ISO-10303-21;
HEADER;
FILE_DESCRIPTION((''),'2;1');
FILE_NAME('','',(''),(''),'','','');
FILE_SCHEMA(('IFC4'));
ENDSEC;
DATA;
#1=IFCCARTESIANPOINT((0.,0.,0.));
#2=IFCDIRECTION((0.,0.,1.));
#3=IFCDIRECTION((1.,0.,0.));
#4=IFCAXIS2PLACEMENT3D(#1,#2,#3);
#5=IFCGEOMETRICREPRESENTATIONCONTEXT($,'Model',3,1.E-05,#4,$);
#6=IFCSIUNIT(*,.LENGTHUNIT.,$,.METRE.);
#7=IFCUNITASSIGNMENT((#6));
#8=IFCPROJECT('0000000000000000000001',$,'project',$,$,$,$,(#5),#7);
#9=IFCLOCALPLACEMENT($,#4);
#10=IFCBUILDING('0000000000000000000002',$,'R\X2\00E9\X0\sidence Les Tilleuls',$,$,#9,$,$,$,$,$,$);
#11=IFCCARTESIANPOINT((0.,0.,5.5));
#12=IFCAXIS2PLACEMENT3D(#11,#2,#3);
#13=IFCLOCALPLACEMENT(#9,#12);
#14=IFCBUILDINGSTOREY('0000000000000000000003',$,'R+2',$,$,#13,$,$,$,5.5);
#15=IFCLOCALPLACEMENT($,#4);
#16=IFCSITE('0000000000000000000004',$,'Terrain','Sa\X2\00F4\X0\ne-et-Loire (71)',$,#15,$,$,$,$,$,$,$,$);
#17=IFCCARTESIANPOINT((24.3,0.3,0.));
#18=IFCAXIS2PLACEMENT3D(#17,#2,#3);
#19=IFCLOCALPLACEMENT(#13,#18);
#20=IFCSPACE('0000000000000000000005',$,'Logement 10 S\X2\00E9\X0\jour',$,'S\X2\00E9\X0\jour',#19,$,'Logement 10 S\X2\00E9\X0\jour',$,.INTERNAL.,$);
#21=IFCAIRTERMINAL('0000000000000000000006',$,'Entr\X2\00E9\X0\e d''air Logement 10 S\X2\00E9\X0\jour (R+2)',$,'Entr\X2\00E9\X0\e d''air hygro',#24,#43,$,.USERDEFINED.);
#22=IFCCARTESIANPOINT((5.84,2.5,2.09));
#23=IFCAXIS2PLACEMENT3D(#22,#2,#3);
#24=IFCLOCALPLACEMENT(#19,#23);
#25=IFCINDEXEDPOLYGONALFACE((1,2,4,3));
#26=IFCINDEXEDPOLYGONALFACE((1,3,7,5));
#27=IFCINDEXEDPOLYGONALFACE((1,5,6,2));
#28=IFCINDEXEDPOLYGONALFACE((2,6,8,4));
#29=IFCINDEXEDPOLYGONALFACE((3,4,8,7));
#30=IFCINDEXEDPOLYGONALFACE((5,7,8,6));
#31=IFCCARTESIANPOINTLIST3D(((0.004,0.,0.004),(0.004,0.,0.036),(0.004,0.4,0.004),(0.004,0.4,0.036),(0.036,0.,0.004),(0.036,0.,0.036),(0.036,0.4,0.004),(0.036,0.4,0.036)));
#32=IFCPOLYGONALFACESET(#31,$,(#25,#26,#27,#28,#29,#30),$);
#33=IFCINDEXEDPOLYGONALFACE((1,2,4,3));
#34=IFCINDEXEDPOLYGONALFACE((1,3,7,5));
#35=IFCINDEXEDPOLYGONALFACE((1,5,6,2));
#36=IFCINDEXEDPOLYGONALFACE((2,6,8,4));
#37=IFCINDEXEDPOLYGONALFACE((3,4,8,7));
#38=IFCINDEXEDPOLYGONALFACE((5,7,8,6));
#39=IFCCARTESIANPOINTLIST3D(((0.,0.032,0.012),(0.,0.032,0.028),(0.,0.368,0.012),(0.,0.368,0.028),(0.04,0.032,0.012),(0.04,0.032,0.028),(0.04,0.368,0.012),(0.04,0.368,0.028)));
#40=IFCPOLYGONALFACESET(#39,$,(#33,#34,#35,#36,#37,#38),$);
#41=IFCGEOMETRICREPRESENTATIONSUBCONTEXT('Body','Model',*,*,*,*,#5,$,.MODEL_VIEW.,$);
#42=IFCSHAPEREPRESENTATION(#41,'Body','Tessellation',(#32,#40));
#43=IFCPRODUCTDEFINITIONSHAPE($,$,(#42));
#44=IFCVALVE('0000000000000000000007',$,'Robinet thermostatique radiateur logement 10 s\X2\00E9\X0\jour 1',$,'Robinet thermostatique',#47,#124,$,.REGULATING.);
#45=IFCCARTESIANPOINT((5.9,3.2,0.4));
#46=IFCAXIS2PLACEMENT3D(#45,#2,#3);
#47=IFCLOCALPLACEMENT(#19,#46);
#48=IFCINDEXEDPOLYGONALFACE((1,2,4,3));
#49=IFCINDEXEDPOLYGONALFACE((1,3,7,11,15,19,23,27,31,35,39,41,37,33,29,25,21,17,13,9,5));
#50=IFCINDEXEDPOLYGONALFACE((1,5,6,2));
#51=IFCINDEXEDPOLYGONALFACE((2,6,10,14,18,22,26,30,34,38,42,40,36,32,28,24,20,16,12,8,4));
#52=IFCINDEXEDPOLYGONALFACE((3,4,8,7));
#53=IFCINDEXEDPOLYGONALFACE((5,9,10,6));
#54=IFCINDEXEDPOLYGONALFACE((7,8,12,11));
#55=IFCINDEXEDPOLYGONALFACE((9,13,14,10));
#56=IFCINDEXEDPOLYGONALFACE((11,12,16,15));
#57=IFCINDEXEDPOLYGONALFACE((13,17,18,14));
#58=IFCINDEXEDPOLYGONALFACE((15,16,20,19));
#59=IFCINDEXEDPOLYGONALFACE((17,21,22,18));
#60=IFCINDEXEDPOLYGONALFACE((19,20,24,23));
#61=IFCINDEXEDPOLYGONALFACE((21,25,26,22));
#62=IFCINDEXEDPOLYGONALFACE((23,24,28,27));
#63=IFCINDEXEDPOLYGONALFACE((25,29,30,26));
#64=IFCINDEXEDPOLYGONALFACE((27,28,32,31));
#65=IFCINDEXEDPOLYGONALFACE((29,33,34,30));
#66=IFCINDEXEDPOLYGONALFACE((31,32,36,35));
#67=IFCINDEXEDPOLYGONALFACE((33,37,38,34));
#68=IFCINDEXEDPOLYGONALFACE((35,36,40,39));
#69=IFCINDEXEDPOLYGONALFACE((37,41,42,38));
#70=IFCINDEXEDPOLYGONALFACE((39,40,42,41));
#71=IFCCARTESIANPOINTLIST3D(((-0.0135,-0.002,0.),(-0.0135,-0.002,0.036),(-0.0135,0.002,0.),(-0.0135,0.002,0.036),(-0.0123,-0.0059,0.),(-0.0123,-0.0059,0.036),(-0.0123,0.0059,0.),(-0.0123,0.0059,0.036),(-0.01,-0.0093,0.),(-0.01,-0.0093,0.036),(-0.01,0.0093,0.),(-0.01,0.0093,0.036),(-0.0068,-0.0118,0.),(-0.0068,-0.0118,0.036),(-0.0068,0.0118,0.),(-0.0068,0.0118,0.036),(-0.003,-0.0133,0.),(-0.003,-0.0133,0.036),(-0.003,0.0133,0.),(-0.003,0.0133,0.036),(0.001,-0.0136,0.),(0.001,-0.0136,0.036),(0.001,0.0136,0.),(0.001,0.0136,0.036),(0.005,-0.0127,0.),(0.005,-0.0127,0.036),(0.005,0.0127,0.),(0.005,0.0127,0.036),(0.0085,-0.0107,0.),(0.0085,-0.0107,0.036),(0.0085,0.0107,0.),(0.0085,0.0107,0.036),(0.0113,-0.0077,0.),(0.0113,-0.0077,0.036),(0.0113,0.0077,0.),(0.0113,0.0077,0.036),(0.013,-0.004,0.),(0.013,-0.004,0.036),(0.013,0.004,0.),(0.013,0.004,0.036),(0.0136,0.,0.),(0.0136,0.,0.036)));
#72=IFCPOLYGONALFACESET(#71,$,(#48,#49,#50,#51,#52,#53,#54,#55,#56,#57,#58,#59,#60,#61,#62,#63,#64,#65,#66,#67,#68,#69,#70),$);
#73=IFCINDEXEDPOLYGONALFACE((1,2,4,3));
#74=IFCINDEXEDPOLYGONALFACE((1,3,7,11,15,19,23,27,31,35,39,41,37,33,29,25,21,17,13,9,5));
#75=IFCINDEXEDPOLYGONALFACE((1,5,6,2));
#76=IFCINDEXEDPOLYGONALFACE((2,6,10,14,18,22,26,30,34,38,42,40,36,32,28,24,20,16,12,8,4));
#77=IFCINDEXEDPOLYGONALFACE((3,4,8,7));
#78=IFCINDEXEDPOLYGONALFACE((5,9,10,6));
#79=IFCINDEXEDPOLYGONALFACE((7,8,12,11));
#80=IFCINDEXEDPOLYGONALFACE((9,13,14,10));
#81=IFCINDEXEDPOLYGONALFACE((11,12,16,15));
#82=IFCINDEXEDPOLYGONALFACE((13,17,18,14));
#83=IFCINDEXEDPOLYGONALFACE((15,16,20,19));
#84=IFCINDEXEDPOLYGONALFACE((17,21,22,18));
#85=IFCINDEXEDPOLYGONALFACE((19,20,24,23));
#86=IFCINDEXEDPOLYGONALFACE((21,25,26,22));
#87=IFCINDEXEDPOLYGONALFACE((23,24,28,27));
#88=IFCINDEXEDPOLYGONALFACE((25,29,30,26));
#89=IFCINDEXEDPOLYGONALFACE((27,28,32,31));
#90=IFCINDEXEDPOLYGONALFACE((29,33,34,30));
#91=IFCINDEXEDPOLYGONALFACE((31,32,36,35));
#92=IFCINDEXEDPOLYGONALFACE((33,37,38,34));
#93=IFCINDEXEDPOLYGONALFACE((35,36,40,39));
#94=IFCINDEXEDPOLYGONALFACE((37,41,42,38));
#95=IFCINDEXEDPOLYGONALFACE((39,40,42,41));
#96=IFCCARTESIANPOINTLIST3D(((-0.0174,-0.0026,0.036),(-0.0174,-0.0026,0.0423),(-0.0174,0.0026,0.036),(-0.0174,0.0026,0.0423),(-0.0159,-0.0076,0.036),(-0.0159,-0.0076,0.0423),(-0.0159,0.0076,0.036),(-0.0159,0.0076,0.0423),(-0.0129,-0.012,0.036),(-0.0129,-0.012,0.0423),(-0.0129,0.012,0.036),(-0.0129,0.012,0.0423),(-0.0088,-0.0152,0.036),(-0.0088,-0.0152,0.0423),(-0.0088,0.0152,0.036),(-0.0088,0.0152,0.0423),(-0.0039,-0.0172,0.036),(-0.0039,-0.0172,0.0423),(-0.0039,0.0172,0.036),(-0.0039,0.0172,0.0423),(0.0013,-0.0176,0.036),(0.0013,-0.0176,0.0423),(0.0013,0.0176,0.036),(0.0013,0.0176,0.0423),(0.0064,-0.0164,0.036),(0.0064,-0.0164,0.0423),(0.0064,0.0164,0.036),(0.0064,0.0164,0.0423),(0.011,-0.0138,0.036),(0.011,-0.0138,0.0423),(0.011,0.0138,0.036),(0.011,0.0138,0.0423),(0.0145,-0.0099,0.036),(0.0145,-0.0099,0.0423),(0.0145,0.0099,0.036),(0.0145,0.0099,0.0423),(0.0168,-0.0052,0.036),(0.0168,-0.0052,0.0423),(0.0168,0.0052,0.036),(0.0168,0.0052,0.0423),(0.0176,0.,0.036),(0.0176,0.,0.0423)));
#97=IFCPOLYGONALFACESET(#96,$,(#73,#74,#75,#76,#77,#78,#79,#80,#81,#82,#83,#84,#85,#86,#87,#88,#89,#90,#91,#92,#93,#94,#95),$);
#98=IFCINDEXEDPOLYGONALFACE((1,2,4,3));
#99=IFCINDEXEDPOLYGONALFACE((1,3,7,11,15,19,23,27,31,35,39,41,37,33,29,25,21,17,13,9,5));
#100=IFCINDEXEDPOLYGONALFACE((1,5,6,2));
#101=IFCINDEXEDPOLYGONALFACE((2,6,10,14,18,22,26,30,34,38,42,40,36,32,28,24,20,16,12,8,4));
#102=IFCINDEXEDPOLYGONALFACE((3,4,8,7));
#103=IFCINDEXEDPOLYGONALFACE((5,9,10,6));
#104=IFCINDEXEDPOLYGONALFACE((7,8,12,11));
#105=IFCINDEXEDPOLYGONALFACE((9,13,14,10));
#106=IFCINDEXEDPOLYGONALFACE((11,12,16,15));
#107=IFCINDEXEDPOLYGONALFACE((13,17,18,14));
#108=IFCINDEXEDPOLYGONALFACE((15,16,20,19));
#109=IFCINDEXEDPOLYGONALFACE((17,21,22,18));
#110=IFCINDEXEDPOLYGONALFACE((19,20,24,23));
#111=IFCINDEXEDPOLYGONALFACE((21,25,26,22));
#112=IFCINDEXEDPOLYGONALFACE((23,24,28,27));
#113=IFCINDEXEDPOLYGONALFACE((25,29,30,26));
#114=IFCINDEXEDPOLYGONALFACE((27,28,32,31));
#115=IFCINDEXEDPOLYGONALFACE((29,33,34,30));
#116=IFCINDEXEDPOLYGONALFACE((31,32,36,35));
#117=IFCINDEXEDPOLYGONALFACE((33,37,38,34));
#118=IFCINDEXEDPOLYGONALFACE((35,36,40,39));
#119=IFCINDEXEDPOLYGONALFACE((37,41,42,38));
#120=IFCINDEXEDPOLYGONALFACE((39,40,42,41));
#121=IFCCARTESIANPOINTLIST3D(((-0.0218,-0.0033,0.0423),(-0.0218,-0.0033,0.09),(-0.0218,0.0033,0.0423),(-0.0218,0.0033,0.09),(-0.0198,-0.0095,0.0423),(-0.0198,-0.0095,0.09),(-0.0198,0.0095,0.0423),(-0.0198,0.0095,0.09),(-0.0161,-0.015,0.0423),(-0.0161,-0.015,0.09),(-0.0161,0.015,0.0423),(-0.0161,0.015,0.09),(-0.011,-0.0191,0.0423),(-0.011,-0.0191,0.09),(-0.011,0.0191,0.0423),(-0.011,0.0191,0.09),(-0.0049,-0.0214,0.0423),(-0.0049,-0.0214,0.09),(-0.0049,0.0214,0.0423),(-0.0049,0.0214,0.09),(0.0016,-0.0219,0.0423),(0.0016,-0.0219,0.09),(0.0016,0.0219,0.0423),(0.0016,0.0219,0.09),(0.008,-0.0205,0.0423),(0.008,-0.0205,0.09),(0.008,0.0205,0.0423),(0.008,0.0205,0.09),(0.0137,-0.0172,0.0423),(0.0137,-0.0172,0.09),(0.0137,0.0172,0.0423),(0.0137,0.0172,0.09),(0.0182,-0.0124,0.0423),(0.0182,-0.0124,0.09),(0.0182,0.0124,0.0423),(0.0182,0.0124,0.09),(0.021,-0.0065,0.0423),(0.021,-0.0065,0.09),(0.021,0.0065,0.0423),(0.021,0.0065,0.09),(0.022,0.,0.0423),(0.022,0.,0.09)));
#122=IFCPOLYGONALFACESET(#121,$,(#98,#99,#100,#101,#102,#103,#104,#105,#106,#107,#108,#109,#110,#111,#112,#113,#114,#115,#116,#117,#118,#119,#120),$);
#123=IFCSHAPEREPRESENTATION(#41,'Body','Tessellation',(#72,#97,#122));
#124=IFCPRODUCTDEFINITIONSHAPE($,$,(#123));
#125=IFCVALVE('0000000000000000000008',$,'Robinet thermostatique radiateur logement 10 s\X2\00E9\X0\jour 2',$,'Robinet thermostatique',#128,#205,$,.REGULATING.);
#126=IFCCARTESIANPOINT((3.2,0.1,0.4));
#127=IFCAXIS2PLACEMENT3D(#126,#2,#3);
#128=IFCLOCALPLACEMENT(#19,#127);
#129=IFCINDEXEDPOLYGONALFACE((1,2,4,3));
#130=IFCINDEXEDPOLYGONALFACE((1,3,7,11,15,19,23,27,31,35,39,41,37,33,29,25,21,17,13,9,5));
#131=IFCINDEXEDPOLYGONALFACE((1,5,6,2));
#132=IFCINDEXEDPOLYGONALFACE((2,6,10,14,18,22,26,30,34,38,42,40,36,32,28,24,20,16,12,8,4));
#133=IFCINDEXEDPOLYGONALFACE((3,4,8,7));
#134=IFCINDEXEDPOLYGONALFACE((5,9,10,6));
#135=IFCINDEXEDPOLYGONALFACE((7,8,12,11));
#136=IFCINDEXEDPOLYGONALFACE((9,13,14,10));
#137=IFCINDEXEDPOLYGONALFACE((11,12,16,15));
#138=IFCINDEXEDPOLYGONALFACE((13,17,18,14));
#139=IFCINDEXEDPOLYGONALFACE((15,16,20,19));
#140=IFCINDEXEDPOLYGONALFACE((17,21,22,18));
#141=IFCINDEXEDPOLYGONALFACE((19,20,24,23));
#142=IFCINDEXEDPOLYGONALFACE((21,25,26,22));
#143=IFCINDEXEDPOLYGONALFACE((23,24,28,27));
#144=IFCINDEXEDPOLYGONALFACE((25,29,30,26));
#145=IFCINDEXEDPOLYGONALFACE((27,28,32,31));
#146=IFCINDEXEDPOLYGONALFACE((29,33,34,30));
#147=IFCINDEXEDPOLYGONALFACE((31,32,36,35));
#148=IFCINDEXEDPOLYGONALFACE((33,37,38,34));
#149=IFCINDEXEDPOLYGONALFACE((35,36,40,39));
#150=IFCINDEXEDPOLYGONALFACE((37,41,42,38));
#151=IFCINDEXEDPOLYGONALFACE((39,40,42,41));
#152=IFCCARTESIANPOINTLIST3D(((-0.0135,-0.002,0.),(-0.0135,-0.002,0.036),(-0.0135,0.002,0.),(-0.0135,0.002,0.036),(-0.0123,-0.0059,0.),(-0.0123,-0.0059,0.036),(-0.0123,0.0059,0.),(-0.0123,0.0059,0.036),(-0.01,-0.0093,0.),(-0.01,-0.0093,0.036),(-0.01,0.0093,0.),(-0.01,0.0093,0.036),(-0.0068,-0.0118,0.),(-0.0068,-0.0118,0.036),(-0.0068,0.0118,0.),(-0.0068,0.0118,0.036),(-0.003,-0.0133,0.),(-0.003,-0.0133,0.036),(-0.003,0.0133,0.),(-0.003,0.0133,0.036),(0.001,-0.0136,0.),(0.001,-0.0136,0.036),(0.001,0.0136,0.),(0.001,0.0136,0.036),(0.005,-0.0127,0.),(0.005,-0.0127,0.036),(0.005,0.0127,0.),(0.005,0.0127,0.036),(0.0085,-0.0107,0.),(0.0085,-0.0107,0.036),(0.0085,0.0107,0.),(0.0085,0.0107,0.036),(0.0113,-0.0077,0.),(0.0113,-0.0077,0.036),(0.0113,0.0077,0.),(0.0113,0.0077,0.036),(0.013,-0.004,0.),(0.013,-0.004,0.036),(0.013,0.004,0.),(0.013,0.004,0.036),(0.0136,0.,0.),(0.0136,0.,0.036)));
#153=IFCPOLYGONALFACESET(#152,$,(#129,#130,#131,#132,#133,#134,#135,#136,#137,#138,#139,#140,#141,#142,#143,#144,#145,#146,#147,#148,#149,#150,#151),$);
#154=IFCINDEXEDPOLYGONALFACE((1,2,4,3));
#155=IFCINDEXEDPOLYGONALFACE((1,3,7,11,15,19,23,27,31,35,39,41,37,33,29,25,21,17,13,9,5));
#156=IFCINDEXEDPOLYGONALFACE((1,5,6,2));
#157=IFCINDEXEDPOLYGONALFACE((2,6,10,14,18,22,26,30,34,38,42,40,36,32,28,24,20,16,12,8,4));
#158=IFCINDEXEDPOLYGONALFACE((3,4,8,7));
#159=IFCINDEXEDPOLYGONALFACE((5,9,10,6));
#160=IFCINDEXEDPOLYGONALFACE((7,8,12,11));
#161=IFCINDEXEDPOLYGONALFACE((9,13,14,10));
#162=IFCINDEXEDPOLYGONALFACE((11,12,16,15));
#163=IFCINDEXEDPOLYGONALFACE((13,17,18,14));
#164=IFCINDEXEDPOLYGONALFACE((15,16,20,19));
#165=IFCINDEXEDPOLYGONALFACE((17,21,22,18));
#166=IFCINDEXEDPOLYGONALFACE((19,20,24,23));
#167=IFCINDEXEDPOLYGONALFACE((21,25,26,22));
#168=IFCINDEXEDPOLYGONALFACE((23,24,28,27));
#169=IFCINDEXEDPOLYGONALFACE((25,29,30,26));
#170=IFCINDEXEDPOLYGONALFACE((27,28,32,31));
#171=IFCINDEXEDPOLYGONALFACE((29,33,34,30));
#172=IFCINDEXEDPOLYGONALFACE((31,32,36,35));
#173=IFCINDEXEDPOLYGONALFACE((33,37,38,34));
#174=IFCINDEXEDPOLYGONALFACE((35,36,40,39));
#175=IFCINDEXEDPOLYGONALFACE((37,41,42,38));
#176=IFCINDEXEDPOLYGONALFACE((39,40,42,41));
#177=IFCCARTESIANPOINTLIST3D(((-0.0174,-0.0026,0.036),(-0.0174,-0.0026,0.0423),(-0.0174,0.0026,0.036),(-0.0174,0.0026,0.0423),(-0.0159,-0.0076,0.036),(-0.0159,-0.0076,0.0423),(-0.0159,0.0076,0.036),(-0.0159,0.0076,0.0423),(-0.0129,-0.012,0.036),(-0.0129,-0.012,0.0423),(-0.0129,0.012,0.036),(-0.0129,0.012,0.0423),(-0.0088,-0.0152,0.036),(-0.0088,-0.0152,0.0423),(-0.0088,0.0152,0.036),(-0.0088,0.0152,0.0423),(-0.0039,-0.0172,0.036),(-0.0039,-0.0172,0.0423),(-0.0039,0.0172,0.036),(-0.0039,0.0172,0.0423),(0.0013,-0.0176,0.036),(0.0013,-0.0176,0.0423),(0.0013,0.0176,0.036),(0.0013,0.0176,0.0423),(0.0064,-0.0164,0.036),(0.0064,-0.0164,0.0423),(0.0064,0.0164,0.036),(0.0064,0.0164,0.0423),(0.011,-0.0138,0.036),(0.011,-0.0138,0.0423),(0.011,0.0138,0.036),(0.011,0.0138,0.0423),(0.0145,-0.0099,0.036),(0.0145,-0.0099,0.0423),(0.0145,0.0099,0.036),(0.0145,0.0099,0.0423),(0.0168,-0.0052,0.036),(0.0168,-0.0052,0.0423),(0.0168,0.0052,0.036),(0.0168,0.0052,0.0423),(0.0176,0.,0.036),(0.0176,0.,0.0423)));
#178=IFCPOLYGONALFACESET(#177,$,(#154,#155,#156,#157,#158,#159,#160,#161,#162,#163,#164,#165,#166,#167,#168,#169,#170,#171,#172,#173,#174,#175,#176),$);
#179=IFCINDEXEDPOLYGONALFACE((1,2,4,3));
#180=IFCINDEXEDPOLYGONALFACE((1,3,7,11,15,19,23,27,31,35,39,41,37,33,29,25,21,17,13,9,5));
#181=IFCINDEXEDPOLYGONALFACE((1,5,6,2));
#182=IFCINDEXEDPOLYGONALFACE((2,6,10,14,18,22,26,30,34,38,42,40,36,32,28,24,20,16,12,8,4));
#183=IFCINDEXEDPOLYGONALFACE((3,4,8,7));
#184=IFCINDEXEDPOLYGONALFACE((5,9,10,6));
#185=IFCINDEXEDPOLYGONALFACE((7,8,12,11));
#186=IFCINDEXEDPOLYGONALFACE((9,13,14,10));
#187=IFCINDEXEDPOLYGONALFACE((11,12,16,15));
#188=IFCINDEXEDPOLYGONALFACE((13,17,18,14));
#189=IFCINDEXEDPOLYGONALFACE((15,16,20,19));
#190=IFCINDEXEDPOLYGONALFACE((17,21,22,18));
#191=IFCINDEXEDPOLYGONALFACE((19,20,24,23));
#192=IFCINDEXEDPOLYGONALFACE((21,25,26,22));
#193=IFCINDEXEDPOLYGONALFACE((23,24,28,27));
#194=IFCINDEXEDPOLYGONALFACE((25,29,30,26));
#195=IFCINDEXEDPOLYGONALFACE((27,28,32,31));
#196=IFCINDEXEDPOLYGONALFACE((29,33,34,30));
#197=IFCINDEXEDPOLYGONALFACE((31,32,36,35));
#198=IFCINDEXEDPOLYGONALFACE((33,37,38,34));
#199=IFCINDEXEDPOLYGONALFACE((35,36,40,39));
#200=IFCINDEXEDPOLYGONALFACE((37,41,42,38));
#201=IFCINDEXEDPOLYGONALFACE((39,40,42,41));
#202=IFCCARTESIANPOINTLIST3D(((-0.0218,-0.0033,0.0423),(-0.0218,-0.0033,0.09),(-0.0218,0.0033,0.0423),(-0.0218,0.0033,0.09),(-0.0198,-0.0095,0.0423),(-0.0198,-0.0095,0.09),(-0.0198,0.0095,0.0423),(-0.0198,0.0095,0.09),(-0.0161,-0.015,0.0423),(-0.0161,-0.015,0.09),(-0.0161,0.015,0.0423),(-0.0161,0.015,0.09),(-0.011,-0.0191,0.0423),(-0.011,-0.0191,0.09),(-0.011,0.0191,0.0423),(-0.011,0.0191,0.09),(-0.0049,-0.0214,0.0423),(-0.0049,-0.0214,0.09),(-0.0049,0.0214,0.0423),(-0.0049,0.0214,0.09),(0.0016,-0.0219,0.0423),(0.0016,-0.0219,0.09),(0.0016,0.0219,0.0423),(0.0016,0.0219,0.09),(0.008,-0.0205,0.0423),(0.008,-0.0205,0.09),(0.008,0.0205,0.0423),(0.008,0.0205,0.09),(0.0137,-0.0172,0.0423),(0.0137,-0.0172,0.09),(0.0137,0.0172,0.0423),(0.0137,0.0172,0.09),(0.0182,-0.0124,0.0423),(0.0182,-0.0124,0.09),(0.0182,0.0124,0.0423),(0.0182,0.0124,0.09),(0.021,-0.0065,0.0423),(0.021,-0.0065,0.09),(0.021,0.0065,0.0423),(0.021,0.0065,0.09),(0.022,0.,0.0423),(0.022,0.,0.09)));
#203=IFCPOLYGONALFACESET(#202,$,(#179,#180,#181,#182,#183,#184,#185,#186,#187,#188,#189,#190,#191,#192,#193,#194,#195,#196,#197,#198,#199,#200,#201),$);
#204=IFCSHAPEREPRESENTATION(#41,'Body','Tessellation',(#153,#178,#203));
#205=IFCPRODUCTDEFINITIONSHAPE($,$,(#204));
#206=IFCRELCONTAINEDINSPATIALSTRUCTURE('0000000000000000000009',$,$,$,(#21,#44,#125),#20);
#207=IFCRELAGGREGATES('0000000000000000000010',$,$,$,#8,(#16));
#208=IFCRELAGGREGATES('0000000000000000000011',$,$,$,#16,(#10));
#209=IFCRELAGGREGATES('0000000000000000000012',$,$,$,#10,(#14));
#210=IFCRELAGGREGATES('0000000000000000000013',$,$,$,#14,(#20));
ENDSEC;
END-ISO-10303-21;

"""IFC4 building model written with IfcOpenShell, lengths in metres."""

from ifc_helpers import new_model, si_unit, frame, frame_2d, origin_with_axes, place, context, subcontext, project, spatial, rectangle, circle, extrude, element, save


model = new_model("IFC4")

# Units and contexts
model_context = context("Model", 3, precision=1e-05, world=origin_with_axes())
body_context = subcontext(model_context, "Body", "Model", "MODEL_VIEW")
ifc_project = project(units=[si_unit("LENGTHUNIT", "METRE")], contexts=[model_context])

# Site, building, storey
site_placement = place(None, origin_with_axes())
site = spatial("IfcSite", under=ifc_project, at=site_placement, Name="Terrain", Description="Saône-et-Loire (71)")
building_placement = place(None, origin_with_axes())
building = spatial("IfcBuilding", under=site, at=building_placement, Name="Résidence Les Tilleuls")
storey_placement = place(building_placement, frame((0.0, 0.0, 5.5), z_axis=(0.0, 0.0, 1.0), x_axis=(1.0, 0.0, 0.0)))
storey = spatial("IfcBuildingStorey", under=building, at=storey_placement, Name="R+2", Elevation=5.5)

# Shared definitions
space_placement = place(storey_placement, frame((24.3, 0.3, 0.0), z_axis=(0.0, 0.0, 1.0), x_axis=(1.0, 0.0, 0.0)))
space = spatial("IfcSpace", under=storey, at=space_placement, Name="Logement 10 Séjour", ObjectType="Séjour", LongName="Logement 10 Séjour", PredefinedType="INTERNAL")

# Air terminal
air_terminal_1_placement = place(space_placement, frame((5.84, 2.5, 2.09), z_axis=(0.0, 0.0, 1.0), x_axis=(1.0, 0.0, 0.0)))
element("IfcAirTerminal", 1, at=air_terminal_1_placement, inside=space, Name="Entrée d'air Logement 10 Séjour (R+2)", ObjectType="Entrée d'air hygro", PredefinedType="USERDEFINED", context=body_context, shape_type="SweptSolid", body=[
    extrude(rectangle(XDim=0.032, YDim=0.4, at=frame_2d((0.016, 0.2))), frame((0.004, 0.0, 0.004), z_axis=(0.0, 0.0, 1.0), x_axis=(1.0, 0.0, 0.0)), (0.0, 0.0, 1.0), 0.032),
    extrude(rectangle(XDim=0.04, YDim=0.336, at=frame_2d((0.02, 0.168))), frame((0.0, 0.032, 0.012), z_axis=(0.0, 0.0, 1.0), x_axis=(1.0, 0.0, 0.0)), (0.0, 0.0, 1.0), 0.016),
])

# Valve
valve_1_placement = place(space_placement, frame((5.9, 3.2, 0.4), z_axis=(0.0, 0.0, 1.0), x_axis=(1.0, 0.0, 0.0)))
element("IfcValve", 2, at=valve_1_placement, inside=space, Name="Robinet thermostatique radiateur logement 10 séjour 1", ObjectType="Robinet thermostatique", PredefinedType="REGULATING", context=body_context, shape_type="SweptSolid", body=[
    extrude(circle(Radius=0.0136), origin_with_axes(), (0.0, 0.0, 1.0), 0.036),
    extrude(circle(Radius=0.0176), frame((0.0, 0.0, 0.036), z_axis=(0.0, 0.0, 1.0), x_axis=(1.0, 0.0, 0.0)), (0.0, 0.0, 1.0), 0.0063),
    extrude(circle(Radius=0.022), frame((0.0, 0.0, 0.0423), z_axis=(0.0, 0.0, 1.0), x_axis=(1.0, 0.0, 0.0)), (0.0, 0.0, 1.0), 0.0477),
])

# Valve
valve_2_placement = place(space_placement, frame((3.2, 0.1, 0.4), z_axis=(0.0, 0.0, 1.0), x_axis=(1.0, 0.0, 0.0)))
element("IfcValve", 3, at=valve_2_placement, inside=space, Name="Robinet thermostatique radiateur logement 10 séjour 2", ObjectType="Robinet thermostatique", PredefinedType="REGULATING", context=body_context, shape_type="SweptSolid", body=[
    extrude(circle(Radius=0.0136), origin_with_axes(), (0.0, 0.0, 1.0), 0.036),
    extrude(circle(Radius=0.0176), frame((0.0, 0.0, 0.036), z_axis=(0.0, 0.0, 1.0), x_axis=(1.0, 0.0, 0.0)), (0.0, 0.0, 1.0), 0.0063),
    extrude(circle(Radius=0.022), frame((0.0, 0.0, 0.0423), z_axis=(0.0, 0.0, 1.0), x_axis=(1.0, 0.0, 0.0)), (0.0, 0.0, 1.0), 0.0477),
])

save(model, "model.ifc")
